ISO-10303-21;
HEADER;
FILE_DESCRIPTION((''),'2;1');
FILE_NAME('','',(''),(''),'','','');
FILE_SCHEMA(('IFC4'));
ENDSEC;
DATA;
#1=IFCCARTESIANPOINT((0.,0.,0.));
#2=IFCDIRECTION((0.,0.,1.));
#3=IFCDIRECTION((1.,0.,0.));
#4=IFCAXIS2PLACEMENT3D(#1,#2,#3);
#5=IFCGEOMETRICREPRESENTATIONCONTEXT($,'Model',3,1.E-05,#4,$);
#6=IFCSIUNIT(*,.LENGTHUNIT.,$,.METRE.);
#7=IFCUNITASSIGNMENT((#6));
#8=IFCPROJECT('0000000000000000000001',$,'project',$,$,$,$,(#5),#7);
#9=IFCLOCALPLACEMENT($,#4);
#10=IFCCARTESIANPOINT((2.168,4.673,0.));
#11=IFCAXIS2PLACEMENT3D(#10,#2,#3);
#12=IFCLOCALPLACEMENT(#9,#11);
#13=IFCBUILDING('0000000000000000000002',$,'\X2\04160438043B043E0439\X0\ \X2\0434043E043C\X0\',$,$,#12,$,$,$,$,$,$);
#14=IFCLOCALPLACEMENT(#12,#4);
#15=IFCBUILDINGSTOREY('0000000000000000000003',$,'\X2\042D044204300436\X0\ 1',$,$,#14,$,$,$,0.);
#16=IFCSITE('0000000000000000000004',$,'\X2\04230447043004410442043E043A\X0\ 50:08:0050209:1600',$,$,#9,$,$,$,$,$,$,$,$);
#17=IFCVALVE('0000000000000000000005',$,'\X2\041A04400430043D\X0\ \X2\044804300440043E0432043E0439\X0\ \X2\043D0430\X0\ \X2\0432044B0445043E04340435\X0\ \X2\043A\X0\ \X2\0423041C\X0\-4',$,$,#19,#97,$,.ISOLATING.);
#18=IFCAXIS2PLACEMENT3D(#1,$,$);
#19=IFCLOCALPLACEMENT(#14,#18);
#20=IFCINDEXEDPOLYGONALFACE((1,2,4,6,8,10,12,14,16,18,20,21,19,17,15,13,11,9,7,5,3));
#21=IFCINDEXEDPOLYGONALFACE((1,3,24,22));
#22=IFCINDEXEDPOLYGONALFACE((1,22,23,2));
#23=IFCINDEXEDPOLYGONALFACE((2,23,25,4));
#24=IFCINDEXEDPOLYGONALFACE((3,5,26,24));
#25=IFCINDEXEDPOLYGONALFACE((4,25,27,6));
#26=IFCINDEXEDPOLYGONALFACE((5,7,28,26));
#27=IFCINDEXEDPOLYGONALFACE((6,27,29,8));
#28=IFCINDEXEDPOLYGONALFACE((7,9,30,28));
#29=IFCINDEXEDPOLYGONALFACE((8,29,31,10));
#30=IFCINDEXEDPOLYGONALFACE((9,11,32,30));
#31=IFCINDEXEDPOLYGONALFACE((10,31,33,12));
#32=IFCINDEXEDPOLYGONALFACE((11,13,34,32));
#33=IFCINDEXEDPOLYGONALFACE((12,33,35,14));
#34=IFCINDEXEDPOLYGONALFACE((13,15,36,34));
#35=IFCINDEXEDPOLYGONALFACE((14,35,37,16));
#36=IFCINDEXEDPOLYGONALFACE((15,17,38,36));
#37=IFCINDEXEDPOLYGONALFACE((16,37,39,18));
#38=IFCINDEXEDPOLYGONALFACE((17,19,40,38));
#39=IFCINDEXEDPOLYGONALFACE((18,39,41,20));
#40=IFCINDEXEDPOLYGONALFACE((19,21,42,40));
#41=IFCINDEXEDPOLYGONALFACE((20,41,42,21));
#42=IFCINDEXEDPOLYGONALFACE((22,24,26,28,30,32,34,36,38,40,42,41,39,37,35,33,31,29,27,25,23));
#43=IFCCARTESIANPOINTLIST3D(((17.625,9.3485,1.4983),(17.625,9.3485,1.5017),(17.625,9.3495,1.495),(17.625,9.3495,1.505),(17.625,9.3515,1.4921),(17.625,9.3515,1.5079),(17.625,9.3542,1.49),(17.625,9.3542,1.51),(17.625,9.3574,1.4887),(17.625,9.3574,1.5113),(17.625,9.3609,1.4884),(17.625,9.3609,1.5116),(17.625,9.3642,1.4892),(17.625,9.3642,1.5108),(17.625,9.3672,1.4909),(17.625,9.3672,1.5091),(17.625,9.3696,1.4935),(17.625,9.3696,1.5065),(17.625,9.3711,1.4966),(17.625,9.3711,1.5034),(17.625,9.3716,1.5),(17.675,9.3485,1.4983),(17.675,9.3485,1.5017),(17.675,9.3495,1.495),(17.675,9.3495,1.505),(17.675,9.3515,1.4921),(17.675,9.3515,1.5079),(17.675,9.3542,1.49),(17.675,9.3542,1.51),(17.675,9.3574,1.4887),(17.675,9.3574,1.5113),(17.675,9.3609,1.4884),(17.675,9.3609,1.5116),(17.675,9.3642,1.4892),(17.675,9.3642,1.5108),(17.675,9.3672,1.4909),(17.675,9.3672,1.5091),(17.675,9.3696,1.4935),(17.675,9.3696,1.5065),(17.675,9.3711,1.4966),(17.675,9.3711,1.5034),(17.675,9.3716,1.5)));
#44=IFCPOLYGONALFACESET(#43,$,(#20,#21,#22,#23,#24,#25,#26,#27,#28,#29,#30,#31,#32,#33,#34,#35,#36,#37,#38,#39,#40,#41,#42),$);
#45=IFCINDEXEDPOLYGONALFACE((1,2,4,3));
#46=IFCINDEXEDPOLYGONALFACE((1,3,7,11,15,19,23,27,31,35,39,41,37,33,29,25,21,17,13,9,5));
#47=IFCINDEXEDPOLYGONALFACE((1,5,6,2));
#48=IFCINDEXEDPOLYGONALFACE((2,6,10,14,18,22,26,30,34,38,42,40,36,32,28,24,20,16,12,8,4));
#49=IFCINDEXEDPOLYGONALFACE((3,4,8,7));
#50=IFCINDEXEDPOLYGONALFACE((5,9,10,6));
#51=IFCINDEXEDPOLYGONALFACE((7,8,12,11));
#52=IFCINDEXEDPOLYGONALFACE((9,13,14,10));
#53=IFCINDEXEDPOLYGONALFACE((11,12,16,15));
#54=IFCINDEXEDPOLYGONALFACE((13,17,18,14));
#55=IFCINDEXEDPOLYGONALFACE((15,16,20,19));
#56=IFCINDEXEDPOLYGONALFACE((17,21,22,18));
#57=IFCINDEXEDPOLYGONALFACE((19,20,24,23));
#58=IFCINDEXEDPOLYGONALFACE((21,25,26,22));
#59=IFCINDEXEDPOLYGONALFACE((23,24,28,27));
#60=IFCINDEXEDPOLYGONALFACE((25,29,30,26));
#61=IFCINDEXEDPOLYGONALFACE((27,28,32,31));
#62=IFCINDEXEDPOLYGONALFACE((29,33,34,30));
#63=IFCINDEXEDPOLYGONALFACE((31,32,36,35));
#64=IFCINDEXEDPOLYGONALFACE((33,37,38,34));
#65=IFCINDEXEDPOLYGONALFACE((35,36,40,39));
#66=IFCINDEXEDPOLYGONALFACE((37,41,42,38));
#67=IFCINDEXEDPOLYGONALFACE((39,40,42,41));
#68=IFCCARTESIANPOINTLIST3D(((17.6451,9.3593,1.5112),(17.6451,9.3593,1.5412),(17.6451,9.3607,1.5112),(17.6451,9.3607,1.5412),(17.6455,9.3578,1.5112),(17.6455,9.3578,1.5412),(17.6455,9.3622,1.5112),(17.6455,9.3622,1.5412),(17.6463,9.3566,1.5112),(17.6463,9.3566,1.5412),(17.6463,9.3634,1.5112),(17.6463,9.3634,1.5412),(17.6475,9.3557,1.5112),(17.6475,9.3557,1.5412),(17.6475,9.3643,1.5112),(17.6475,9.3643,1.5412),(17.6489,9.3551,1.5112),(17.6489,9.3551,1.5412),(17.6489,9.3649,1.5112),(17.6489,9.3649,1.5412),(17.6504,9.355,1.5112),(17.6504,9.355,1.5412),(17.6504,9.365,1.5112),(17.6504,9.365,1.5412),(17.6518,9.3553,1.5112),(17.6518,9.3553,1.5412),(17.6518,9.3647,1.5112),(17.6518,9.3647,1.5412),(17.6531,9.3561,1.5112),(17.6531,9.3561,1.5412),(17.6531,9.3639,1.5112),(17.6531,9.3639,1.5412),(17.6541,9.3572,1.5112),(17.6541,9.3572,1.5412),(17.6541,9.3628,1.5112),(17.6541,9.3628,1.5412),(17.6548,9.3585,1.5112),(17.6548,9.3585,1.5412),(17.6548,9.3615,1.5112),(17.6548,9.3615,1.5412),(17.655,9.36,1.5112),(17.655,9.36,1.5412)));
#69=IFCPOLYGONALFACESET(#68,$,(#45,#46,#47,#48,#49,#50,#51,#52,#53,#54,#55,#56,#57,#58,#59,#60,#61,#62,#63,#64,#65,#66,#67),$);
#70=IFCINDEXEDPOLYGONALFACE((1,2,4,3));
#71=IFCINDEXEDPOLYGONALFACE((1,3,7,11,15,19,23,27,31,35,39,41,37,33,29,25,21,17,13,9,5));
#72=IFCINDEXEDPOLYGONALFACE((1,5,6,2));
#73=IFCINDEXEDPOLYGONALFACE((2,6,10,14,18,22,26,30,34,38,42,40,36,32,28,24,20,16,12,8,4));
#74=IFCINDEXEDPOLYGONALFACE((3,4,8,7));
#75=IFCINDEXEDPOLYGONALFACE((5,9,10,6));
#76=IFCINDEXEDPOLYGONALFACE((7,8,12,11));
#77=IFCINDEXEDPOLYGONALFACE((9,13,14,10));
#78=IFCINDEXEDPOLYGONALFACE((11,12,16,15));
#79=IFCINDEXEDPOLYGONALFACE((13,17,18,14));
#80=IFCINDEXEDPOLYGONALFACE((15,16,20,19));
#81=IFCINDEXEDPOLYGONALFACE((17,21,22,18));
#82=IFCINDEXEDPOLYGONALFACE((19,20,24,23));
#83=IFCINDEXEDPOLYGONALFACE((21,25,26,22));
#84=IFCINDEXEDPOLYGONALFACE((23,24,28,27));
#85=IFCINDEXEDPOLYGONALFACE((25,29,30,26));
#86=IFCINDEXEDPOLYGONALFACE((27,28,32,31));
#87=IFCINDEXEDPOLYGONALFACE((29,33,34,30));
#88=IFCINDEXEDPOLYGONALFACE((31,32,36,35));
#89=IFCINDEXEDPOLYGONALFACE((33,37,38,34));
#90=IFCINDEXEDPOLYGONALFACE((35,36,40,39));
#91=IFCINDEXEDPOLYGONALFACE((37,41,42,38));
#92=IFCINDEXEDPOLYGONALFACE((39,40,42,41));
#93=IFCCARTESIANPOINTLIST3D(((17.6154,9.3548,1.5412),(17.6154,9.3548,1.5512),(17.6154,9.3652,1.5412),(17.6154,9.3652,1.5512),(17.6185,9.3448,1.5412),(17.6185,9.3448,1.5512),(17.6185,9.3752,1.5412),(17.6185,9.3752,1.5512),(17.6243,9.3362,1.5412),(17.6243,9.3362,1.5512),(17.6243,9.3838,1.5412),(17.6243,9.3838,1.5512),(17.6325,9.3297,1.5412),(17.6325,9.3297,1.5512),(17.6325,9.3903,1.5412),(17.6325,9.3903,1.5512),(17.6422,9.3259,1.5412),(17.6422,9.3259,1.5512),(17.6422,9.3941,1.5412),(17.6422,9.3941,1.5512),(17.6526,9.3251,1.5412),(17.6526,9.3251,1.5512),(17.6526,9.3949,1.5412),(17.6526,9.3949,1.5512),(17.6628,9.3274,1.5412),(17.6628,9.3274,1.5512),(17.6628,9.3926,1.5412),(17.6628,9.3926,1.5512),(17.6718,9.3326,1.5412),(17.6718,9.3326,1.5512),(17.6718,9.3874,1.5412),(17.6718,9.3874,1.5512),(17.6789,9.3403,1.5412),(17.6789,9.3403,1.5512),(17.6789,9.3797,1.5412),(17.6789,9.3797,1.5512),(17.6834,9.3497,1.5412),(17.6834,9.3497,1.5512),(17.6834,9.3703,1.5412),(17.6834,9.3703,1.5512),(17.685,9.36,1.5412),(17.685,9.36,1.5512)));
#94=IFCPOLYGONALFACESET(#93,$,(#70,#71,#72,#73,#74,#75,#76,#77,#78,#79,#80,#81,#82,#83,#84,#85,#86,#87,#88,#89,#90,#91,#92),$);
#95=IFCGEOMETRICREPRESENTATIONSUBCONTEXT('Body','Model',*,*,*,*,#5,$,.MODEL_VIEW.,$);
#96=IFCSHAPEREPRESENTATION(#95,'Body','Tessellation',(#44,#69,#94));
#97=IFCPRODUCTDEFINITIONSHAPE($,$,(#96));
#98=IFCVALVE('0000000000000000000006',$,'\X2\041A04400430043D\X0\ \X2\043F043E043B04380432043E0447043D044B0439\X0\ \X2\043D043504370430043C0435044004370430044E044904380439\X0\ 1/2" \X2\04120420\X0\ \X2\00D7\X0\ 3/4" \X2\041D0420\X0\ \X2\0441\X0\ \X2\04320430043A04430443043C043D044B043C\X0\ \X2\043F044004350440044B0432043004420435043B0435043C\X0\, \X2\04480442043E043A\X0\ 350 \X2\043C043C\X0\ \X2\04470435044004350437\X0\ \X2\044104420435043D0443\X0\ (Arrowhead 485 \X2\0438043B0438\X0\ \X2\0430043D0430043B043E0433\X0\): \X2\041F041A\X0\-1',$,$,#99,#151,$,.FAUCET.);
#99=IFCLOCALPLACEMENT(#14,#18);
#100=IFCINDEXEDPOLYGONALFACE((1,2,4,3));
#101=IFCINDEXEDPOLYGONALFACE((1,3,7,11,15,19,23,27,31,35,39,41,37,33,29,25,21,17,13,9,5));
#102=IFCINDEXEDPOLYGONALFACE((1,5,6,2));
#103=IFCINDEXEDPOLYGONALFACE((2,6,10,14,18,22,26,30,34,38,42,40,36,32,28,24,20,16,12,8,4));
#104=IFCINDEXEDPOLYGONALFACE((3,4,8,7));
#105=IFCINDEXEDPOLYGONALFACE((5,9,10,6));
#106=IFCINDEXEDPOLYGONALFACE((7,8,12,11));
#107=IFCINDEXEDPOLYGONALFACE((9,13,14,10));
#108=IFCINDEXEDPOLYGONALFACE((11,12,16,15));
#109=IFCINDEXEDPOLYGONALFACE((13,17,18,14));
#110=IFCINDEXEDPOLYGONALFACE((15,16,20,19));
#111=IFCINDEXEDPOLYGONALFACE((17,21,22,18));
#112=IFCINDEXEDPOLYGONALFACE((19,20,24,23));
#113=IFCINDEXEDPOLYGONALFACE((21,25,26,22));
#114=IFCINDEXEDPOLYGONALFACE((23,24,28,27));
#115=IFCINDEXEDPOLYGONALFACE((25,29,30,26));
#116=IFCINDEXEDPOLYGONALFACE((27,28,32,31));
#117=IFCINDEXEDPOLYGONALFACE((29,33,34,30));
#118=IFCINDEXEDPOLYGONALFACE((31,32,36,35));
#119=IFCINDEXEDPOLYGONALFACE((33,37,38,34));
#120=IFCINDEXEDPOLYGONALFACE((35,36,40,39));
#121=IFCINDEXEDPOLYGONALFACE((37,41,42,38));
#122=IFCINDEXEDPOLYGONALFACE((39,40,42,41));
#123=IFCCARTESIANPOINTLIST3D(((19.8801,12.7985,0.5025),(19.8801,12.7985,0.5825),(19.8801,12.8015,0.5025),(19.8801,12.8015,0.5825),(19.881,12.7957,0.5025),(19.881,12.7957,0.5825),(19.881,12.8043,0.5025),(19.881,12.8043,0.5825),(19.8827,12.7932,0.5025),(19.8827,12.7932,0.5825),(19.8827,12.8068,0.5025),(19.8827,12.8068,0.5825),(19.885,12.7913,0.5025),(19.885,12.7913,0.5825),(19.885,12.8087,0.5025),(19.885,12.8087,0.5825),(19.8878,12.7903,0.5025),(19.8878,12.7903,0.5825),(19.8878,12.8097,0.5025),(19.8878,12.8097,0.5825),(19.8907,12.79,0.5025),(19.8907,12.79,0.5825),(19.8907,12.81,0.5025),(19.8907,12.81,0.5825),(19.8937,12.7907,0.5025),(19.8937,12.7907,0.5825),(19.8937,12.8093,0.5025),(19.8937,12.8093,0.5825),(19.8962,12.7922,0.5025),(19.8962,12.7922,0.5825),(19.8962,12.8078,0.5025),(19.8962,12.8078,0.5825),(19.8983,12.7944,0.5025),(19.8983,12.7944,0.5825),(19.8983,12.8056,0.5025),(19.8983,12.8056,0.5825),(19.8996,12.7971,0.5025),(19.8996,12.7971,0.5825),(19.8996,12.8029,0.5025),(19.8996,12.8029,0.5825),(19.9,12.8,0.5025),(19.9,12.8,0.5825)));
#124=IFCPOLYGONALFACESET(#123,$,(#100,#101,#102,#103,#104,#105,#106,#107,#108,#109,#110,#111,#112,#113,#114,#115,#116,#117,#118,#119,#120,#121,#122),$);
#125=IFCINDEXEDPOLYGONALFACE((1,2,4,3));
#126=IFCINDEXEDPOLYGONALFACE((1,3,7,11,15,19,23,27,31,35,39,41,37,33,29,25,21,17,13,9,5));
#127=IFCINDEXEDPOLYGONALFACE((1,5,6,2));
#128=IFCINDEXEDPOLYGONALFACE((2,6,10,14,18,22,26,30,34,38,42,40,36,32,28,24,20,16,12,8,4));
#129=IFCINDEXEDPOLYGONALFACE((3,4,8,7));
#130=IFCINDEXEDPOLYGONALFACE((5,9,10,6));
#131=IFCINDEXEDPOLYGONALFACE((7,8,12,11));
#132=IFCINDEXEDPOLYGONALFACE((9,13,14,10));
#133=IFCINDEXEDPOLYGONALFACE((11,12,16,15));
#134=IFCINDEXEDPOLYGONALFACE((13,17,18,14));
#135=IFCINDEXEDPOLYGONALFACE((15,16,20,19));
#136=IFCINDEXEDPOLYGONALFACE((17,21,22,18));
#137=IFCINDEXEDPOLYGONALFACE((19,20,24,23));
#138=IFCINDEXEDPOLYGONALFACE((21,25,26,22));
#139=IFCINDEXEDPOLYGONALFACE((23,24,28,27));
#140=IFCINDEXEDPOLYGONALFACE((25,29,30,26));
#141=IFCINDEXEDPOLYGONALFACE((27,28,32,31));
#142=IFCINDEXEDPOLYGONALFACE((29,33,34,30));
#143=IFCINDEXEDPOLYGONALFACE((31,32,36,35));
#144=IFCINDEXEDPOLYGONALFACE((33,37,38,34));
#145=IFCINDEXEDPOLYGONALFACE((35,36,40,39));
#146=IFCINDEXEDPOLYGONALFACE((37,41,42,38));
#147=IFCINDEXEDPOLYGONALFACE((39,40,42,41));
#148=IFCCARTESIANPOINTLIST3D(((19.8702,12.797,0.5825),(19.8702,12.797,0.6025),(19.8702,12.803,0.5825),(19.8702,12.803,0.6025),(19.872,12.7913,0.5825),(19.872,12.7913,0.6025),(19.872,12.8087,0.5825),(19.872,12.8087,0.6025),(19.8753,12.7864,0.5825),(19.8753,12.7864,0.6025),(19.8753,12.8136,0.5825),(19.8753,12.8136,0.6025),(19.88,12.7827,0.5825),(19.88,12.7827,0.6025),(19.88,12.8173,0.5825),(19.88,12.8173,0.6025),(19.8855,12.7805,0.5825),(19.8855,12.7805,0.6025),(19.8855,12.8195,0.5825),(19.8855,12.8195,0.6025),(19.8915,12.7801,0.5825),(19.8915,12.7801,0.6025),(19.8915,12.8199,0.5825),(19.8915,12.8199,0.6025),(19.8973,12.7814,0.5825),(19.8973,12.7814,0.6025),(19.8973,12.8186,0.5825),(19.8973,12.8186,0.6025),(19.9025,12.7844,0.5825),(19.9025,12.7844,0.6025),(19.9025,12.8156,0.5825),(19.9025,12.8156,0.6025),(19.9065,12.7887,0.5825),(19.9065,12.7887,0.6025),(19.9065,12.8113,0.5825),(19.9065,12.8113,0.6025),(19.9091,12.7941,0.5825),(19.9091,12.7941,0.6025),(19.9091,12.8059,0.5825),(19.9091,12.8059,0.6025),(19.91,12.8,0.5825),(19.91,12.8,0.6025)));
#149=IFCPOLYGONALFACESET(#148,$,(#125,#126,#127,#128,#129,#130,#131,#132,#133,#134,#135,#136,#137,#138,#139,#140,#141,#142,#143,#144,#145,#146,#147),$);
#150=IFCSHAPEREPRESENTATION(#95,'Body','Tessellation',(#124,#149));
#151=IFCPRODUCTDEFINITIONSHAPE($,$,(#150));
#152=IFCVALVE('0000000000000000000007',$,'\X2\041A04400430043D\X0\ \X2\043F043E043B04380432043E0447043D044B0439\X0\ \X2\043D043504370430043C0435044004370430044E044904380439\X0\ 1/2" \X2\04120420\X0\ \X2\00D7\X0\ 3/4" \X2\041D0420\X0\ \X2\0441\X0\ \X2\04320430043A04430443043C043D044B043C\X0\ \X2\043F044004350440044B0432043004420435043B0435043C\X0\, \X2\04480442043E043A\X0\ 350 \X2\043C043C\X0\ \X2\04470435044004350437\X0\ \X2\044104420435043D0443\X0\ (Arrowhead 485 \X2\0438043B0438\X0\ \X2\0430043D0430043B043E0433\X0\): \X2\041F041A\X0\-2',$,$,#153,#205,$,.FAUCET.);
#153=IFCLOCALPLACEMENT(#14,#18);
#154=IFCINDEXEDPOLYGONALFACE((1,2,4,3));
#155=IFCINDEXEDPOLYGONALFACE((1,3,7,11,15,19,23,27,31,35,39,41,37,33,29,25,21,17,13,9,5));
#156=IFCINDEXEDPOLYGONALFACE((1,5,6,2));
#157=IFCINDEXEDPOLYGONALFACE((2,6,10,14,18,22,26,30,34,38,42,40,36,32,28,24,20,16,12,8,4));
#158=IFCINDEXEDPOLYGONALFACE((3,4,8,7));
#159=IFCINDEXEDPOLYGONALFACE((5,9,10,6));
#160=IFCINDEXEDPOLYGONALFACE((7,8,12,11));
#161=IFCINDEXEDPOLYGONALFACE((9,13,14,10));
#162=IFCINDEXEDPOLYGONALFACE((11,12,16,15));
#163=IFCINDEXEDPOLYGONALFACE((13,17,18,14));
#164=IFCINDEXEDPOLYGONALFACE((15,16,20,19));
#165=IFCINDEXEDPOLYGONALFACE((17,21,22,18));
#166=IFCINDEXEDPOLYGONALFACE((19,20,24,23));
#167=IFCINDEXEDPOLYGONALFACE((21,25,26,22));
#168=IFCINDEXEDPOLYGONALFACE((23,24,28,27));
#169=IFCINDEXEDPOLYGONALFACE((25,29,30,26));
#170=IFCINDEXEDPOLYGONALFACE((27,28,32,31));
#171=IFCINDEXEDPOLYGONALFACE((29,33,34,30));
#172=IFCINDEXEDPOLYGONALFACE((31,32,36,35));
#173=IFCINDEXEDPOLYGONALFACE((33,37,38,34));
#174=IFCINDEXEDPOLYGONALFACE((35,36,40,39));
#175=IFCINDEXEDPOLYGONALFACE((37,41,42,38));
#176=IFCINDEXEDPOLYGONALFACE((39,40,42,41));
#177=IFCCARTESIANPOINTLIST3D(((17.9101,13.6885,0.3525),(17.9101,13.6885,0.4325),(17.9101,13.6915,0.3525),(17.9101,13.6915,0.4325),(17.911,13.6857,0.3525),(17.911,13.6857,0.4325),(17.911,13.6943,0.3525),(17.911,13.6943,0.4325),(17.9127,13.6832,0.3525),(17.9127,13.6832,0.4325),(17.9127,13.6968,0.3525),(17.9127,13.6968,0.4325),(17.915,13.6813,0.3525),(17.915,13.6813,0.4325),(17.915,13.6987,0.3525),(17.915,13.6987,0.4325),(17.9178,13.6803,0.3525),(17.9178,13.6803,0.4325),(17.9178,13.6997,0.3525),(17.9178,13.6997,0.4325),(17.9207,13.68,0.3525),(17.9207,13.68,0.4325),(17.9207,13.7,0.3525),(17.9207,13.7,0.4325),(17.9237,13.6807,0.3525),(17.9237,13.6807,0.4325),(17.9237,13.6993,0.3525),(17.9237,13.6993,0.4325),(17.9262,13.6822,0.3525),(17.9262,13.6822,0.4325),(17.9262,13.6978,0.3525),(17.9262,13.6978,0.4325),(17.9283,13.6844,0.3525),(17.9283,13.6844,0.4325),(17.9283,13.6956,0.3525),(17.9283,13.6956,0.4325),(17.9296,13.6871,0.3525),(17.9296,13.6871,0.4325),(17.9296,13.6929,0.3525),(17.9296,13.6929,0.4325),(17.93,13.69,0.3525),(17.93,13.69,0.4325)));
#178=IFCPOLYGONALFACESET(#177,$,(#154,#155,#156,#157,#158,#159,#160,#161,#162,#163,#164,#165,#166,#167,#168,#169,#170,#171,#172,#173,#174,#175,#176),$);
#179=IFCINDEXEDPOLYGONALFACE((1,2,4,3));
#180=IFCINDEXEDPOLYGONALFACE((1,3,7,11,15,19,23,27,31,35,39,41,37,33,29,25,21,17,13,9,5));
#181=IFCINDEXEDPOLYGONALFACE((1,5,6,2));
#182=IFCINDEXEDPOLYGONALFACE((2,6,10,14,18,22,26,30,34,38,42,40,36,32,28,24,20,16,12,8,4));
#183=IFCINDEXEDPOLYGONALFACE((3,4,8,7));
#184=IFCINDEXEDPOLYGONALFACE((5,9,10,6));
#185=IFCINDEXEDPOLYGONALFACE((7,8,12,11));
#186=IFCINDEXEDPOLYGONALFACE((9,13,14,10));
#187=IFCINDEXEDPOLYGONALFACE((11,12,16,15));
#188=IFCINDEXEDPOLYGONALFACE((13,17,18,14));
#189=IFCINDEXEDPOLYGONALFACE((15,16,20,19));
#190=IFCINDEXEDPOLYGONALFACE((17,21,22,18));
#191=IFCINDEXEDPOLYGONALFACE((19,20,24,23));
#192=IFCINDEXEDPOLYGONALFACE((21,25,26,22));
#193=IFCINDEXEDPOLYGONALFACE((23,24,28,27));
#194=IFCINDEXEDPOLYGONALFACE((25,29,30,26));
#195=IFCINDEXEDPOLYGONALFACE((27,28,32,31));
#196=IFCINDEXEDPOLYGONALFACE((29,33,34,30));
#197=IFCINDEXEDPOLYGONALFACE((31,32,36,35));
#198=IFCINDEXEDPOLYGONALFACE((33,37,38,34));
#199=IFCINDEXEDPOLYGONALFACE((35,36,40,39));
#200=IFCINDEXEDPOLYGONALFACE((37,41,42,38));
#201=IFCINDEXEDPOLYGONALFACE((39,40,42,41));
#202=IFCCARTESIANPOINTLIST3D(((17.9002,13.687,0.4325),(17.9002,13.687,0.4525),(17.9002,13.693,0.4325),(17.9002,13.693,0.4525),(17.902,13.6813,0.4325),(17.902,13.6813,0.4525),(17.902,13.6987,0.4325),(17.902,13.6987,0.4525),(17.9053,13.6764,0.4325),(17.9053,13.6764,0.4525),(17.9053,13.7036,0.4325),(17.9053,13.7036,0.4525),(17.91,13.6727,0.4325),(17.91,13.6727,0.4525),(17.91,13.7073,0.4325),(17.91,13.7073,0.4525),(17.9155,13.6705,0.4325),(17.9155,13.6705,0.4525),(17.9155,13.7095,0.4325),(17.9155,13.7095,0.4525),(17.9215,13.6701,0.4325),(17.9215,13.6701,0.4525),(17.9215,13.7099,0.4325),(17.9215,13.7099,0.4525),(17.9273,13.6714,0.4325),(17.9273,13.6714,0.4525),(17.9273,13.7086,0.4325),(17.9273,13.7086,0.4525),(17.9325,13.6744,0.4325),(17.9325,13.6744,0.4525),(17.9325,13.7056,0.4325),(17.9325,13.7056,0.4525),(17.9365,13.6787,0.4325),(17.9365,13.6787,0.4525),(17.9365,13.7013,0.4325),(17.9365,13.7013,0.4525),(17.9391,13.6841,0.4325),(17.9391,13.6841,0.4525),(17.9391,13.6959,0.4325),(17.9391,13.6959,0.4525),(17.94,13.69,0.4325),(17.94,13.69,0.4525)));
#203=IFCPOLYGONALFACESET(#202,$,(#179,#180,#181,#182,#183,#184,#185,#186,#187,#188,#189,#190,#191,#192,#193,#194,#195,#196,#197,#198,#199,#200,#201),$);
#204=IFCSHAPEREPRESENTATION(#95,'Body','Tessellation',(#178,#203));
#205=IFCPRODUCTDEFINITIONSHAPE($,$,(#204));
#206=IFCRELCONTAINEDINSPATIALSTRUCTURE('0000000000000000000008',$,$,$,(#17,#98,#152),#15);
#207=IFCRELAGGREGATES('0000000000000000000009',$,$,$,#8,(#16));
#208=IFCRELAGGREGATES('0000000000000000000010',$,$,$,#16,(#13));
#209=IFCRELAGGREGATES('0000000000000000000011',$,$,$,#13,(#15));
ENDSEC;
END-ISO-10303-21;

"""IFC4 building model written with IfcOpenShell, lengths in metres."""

from ifc_helpers import new_model, si_unit, frame, origin_with_axes, origin_2d, place, context, subcontext, project, spatial, circle, extrude, element, save


model = new_model("IFC4")

# Units and contexts
model_context = context("Model", 3, precision=1e-05, world=origin_with_axes())
body_context = subcontext(model_context, "Body", "Model", "MODEL_VIEW")
ifc_project = project(units=[si_unit("LENGTHUNIT", "METRE")], contexts=[model_context])

# Site, building, storey
site_placement = place(None, origin_with_axes())
site = spatial("IfcSite", under=ifc_project, at=site_placement, Name="Участок 50:08:0050209:1600")
building_placement = place(site_placement, frame((2.168, 4.673, 0.0), z_axis=(0.0, 0.0, 1.0), x_axis=(1.0, 0.0, 0.0)))
building = spatial("IfcBuilding", under=site, at=building_placement, Name="Жилой дом")
storey_placement = place(building_placement, origin_with_axes())
storey = spatial("IfcBuildingStorey", under=building, at=storey_placement, Name="Этаж 1", Elevation=0.0)

# Valves
valve_1_placement = place(storey_placement, origin_with_axes())
element("IfcValve", 1, at=valve_1_placement, inside=storey, Name="Кран шаровой на выходе к УМ-4", PredefinedType="ISOLATING", context=body_context, shape_type="SweptSolid", body=[
    extrude(circle(Radius=0.0116, at=origin_2d()), frame((17.625, 9.36, 1.5), z_axis=(1.0, 0.0, 0.0), x_axis=(0.0, 1.0, 0.0)), (0.0, 0.0, 1.0), 0.05),
    extrude(circle(Radius=0.005, at=origin_2d()), frame((17.65, 9.36, 1.5112), z_axis=(0.0, 0.0, 1.0), x_axis=(1.0, 0.0, 0.0)), (0.0, 0.0, 1.0), 0.03),
    extrude(circle(Radius=0.035, at=origin_2d()), frame((17.65, 9.36, 1.5412), z_axis=(0.0, 0.0, 1.0), x_axis=(1.0, 0.0, 0.0)), (0.0, 0.0, 1.0), 0.01),
])
valve_2_placement = place(storey_placement, origin_with_axes())
element("IfcValve", 2, at=valve_2_placement, inside=storey, Name="Кран поливочный незамерзающий 1/2\" ВР × 3/4\" НР с вакуумным прерывателем, шток 350 мм через стену (Arrowhead 485 или аналог): ПК-1", PredefinedType="FAUCET", context=body_context, shape_type="SweptSolid", body=[
    extrude(circle(Radius=0.01, at=origin_2d()), frame((19.89, 12.8, 0.5025), z_axis=(0.0, 0.0, 1.0), x_axis=(1.0, 0.0, 0.0)), (0.0, 0.0, 1.0), 0.08),
    extrude(circle(Radius=0.02, at=origin_2d()), frame((19.89, 12.8, 0.5825), z_axis=(0.0, 0.0, 1.0), x_axis=(1.0, 0.0, 0.0)), (0.0, 0.0, 1.0), 0.02),
])
valve_3_placement = place(storey_placement, origin_with_axes())
element("IfcValve", 3, at=valve_3_placement, inside=storey, Name="Кран поливочный незамерзающий 1/2\" ВР × 3/4\" НР с вакуумным прерывателем, шток 350 мм через стену (Arrowhead 485 или аналог): ПК-2", PredefinedType="FAUCET", context=body_context, shape_type="SweptSolid", body=[
    extrude(circle(Radius=0.01, at=origin_2d()), frame((17.92, 13.69, 0.3525), z_axis=(0.0, 0.0, 1.0), x_axis=(1.0, 0.0, 0.0)), (0.0, 0.0, 1.0), 0.08),
    extrude(circle(Radius=0.02, at=origin_2d()), frame((17.92, 13.69, 0.4325), z_axis=(0.0, 0.0, 1.0), x_axis=(1.0, 0.0, 0.0)), (0.0, 0.0, 1.0), 0.02),
])

save(model, "model.ifc")
